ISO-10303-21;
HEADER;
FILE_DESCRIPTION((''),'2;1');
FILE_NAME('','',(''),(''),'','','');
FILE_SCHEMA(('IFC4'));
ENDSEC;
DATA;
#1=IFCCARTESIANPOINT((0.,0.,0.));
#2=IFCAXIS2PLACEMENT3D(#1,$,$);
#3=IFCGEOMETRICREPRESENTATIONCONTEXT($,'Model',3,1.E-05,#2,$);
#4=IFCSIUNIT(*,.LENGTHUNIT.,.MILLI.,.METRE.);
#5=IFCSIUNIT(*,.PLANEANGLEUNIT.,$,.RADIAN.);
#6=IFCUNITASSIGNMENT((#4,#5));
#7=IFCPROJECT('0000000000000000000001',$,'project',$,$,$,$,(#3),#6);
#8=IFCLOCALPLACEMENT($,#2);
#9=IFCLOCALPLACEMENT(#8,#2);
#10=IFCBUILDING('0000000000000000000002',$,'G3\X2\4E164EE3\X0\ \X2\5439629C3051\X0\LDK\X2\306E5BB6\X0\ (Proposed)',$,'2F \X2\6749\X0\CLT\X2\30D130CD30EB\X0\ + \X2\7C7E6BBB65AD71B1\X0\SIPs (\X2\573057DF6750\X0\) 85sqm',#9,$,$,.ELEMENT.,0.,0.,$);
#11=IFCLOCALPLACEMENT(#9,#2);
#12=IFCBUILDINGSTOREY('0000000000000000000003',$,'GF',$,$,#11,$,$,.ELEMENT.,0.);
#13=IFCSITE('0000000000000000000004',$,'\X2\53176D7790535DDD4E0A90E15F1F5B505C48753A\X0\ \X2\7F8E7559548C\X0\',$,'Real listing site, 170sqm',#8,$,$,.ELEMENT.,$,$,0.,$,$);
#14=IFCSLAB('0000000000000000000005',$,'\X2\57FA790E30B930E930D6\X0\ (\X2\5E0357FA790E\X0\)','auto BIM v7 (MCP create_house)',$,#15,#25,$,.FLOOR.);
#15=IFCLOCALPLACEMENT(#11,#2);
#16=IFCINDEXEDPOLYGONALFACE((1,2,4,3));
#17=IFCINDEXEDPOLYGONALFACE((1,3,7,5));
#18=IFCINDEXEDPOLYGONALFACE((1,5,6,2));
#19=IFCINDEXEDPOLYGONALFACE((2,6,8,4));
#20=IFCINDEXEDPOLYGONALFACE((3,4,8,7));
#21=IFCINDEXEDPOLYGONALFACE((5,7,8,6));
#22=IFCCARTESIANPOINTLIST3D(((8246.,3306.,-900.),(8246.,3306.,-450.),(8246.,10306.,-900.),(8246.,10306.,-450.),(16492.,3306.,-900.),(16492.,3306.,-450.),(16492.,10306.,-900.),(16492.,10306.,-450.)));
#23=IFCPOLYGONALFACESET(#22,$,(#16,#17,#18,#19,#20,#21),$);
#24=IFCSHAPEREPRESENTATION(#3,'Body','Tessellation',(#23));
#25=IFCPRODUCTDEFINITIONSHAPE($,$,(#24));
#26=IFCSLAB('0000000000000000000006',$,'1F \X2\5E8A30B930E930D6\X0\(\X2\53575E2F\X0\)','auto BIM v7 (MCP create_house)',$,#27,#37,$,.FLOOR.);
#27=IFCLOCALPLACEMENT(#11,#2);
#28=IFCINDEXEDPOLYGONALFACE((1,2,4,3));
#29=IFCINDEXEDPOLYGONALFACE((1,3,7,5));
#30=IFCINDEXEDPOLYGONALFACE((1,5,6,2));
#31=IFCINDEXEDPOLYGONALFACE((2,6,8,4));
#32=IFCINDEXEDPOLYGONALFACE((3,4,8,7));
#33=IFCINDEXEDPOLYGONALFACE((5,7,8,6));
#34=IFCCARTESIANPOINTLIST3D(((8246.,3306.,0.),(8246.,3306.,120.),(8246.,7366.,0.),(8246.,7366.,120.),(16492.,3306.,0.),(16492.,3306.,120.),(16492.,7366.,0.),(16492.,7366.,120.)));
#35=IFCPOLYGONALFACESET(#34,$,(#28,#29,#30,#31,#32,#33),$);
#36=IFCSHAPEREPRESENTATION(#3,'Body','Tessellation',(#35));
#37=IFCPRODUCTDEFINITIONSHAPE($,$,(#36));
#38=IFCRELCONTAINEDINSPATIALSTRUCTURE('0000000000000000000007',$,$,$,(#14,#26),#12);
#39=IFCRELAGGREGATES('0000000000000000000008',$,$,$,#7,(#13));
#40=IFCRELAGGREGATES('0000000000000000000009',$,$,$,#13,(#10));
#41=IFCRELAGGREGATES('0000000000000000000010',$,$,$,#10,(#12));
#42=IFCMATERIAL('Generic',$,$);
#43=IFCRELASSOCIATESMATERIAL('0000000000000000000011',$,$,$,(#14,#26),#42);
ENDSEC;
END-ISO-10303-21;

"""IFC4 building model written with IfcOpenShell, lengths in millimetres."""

from ifc_helpers import new_model, si_unit, frame, frame_2d, origin, place, context, project, spatial, rectangle, extrude, material, element, save


model = new_model("IFC4")

# Units and contexts
model_context = context("Model", 3, precision=1e-05, world=origin())
ifc_project = project(units=[si_unit("LENGTHUNIT", "METRE", prefix="MILLI"), si_unit("PLANEANGLEUNIT", "RADIAN")], contexts=[model_context])

# Site, building, storey
site_placement = place(None, origin())
site = spatial("IfcSite", under=ifc_project, at=site_placement, Name="北海道川上郡弟子屈町 美留和", ObjectType="Real listing site, 170sqm", CompositionType="ELEMENT", RefElevation=0.0)
building_placement = place(site_placement, origin())
building = spatial("IfcBuilding", under=site, at=building_placement, Name="G3世代 吹抜けLDKの家 (Proposed)", ObjectType="2F 杉CLTパネル + 籾殻断熱SIPs (地域材) 85sqm", CompositionType="ELEMENT", ElevationOfRefHeight=0.0, ElevationOfTerrain=0.0)
storey_placement = place(building_placement, origin())
storey = spatial("IfcBuildingStorey", under=building, at=storey_placement, Name="GF", CompositionType="ELEMENT", Elevation=0.0)

# Slabs
ifc_material = material(Name="Generic")
slab_1_placement = place(storey_placement, frame((4123.0, 1653.0, -450.0)))
element("IfcSlab", 1, at=slab_1_placement, inside=storey, material=ifc_material, Name="基礎スラブ (布基礎)", Description="auto BIM v7 (MCP create_house)", PredefinedType="FLOOR", context=model_context, shape_type="SweptSolid", body=[
    extrude(rectangle(XDim=8246.0, YDim=7000.0, at=frame_2d((4123.0, 3500.0))), frame((4123.0, 1653.0, -450.0)), (0.0, 0.0, 1.0), 450.0),
])
slab_2_placement = place(storey_placement, frame((4123.0, 1653.0, 0.0)))
element("IfcSlab", 2, at=slab_2_placement, inside=storey, material=ifc_material, Name="1F 床スラブ(南帯)", Description="auto BIM v7 (MCP create_house)", PredefinedType="FLOOR", context=model_context, shape_type="SweptSolid", body=[
    extrude(rectangle(XDim=8246.0, YDim=4060.0, at=frame_2d((4123.0, 2030.0))), frame((4123.0, 1653.0, 0.0)), (0.0, 0.0, 1.0), 120.0),
])

save(model, "model.ifc")
